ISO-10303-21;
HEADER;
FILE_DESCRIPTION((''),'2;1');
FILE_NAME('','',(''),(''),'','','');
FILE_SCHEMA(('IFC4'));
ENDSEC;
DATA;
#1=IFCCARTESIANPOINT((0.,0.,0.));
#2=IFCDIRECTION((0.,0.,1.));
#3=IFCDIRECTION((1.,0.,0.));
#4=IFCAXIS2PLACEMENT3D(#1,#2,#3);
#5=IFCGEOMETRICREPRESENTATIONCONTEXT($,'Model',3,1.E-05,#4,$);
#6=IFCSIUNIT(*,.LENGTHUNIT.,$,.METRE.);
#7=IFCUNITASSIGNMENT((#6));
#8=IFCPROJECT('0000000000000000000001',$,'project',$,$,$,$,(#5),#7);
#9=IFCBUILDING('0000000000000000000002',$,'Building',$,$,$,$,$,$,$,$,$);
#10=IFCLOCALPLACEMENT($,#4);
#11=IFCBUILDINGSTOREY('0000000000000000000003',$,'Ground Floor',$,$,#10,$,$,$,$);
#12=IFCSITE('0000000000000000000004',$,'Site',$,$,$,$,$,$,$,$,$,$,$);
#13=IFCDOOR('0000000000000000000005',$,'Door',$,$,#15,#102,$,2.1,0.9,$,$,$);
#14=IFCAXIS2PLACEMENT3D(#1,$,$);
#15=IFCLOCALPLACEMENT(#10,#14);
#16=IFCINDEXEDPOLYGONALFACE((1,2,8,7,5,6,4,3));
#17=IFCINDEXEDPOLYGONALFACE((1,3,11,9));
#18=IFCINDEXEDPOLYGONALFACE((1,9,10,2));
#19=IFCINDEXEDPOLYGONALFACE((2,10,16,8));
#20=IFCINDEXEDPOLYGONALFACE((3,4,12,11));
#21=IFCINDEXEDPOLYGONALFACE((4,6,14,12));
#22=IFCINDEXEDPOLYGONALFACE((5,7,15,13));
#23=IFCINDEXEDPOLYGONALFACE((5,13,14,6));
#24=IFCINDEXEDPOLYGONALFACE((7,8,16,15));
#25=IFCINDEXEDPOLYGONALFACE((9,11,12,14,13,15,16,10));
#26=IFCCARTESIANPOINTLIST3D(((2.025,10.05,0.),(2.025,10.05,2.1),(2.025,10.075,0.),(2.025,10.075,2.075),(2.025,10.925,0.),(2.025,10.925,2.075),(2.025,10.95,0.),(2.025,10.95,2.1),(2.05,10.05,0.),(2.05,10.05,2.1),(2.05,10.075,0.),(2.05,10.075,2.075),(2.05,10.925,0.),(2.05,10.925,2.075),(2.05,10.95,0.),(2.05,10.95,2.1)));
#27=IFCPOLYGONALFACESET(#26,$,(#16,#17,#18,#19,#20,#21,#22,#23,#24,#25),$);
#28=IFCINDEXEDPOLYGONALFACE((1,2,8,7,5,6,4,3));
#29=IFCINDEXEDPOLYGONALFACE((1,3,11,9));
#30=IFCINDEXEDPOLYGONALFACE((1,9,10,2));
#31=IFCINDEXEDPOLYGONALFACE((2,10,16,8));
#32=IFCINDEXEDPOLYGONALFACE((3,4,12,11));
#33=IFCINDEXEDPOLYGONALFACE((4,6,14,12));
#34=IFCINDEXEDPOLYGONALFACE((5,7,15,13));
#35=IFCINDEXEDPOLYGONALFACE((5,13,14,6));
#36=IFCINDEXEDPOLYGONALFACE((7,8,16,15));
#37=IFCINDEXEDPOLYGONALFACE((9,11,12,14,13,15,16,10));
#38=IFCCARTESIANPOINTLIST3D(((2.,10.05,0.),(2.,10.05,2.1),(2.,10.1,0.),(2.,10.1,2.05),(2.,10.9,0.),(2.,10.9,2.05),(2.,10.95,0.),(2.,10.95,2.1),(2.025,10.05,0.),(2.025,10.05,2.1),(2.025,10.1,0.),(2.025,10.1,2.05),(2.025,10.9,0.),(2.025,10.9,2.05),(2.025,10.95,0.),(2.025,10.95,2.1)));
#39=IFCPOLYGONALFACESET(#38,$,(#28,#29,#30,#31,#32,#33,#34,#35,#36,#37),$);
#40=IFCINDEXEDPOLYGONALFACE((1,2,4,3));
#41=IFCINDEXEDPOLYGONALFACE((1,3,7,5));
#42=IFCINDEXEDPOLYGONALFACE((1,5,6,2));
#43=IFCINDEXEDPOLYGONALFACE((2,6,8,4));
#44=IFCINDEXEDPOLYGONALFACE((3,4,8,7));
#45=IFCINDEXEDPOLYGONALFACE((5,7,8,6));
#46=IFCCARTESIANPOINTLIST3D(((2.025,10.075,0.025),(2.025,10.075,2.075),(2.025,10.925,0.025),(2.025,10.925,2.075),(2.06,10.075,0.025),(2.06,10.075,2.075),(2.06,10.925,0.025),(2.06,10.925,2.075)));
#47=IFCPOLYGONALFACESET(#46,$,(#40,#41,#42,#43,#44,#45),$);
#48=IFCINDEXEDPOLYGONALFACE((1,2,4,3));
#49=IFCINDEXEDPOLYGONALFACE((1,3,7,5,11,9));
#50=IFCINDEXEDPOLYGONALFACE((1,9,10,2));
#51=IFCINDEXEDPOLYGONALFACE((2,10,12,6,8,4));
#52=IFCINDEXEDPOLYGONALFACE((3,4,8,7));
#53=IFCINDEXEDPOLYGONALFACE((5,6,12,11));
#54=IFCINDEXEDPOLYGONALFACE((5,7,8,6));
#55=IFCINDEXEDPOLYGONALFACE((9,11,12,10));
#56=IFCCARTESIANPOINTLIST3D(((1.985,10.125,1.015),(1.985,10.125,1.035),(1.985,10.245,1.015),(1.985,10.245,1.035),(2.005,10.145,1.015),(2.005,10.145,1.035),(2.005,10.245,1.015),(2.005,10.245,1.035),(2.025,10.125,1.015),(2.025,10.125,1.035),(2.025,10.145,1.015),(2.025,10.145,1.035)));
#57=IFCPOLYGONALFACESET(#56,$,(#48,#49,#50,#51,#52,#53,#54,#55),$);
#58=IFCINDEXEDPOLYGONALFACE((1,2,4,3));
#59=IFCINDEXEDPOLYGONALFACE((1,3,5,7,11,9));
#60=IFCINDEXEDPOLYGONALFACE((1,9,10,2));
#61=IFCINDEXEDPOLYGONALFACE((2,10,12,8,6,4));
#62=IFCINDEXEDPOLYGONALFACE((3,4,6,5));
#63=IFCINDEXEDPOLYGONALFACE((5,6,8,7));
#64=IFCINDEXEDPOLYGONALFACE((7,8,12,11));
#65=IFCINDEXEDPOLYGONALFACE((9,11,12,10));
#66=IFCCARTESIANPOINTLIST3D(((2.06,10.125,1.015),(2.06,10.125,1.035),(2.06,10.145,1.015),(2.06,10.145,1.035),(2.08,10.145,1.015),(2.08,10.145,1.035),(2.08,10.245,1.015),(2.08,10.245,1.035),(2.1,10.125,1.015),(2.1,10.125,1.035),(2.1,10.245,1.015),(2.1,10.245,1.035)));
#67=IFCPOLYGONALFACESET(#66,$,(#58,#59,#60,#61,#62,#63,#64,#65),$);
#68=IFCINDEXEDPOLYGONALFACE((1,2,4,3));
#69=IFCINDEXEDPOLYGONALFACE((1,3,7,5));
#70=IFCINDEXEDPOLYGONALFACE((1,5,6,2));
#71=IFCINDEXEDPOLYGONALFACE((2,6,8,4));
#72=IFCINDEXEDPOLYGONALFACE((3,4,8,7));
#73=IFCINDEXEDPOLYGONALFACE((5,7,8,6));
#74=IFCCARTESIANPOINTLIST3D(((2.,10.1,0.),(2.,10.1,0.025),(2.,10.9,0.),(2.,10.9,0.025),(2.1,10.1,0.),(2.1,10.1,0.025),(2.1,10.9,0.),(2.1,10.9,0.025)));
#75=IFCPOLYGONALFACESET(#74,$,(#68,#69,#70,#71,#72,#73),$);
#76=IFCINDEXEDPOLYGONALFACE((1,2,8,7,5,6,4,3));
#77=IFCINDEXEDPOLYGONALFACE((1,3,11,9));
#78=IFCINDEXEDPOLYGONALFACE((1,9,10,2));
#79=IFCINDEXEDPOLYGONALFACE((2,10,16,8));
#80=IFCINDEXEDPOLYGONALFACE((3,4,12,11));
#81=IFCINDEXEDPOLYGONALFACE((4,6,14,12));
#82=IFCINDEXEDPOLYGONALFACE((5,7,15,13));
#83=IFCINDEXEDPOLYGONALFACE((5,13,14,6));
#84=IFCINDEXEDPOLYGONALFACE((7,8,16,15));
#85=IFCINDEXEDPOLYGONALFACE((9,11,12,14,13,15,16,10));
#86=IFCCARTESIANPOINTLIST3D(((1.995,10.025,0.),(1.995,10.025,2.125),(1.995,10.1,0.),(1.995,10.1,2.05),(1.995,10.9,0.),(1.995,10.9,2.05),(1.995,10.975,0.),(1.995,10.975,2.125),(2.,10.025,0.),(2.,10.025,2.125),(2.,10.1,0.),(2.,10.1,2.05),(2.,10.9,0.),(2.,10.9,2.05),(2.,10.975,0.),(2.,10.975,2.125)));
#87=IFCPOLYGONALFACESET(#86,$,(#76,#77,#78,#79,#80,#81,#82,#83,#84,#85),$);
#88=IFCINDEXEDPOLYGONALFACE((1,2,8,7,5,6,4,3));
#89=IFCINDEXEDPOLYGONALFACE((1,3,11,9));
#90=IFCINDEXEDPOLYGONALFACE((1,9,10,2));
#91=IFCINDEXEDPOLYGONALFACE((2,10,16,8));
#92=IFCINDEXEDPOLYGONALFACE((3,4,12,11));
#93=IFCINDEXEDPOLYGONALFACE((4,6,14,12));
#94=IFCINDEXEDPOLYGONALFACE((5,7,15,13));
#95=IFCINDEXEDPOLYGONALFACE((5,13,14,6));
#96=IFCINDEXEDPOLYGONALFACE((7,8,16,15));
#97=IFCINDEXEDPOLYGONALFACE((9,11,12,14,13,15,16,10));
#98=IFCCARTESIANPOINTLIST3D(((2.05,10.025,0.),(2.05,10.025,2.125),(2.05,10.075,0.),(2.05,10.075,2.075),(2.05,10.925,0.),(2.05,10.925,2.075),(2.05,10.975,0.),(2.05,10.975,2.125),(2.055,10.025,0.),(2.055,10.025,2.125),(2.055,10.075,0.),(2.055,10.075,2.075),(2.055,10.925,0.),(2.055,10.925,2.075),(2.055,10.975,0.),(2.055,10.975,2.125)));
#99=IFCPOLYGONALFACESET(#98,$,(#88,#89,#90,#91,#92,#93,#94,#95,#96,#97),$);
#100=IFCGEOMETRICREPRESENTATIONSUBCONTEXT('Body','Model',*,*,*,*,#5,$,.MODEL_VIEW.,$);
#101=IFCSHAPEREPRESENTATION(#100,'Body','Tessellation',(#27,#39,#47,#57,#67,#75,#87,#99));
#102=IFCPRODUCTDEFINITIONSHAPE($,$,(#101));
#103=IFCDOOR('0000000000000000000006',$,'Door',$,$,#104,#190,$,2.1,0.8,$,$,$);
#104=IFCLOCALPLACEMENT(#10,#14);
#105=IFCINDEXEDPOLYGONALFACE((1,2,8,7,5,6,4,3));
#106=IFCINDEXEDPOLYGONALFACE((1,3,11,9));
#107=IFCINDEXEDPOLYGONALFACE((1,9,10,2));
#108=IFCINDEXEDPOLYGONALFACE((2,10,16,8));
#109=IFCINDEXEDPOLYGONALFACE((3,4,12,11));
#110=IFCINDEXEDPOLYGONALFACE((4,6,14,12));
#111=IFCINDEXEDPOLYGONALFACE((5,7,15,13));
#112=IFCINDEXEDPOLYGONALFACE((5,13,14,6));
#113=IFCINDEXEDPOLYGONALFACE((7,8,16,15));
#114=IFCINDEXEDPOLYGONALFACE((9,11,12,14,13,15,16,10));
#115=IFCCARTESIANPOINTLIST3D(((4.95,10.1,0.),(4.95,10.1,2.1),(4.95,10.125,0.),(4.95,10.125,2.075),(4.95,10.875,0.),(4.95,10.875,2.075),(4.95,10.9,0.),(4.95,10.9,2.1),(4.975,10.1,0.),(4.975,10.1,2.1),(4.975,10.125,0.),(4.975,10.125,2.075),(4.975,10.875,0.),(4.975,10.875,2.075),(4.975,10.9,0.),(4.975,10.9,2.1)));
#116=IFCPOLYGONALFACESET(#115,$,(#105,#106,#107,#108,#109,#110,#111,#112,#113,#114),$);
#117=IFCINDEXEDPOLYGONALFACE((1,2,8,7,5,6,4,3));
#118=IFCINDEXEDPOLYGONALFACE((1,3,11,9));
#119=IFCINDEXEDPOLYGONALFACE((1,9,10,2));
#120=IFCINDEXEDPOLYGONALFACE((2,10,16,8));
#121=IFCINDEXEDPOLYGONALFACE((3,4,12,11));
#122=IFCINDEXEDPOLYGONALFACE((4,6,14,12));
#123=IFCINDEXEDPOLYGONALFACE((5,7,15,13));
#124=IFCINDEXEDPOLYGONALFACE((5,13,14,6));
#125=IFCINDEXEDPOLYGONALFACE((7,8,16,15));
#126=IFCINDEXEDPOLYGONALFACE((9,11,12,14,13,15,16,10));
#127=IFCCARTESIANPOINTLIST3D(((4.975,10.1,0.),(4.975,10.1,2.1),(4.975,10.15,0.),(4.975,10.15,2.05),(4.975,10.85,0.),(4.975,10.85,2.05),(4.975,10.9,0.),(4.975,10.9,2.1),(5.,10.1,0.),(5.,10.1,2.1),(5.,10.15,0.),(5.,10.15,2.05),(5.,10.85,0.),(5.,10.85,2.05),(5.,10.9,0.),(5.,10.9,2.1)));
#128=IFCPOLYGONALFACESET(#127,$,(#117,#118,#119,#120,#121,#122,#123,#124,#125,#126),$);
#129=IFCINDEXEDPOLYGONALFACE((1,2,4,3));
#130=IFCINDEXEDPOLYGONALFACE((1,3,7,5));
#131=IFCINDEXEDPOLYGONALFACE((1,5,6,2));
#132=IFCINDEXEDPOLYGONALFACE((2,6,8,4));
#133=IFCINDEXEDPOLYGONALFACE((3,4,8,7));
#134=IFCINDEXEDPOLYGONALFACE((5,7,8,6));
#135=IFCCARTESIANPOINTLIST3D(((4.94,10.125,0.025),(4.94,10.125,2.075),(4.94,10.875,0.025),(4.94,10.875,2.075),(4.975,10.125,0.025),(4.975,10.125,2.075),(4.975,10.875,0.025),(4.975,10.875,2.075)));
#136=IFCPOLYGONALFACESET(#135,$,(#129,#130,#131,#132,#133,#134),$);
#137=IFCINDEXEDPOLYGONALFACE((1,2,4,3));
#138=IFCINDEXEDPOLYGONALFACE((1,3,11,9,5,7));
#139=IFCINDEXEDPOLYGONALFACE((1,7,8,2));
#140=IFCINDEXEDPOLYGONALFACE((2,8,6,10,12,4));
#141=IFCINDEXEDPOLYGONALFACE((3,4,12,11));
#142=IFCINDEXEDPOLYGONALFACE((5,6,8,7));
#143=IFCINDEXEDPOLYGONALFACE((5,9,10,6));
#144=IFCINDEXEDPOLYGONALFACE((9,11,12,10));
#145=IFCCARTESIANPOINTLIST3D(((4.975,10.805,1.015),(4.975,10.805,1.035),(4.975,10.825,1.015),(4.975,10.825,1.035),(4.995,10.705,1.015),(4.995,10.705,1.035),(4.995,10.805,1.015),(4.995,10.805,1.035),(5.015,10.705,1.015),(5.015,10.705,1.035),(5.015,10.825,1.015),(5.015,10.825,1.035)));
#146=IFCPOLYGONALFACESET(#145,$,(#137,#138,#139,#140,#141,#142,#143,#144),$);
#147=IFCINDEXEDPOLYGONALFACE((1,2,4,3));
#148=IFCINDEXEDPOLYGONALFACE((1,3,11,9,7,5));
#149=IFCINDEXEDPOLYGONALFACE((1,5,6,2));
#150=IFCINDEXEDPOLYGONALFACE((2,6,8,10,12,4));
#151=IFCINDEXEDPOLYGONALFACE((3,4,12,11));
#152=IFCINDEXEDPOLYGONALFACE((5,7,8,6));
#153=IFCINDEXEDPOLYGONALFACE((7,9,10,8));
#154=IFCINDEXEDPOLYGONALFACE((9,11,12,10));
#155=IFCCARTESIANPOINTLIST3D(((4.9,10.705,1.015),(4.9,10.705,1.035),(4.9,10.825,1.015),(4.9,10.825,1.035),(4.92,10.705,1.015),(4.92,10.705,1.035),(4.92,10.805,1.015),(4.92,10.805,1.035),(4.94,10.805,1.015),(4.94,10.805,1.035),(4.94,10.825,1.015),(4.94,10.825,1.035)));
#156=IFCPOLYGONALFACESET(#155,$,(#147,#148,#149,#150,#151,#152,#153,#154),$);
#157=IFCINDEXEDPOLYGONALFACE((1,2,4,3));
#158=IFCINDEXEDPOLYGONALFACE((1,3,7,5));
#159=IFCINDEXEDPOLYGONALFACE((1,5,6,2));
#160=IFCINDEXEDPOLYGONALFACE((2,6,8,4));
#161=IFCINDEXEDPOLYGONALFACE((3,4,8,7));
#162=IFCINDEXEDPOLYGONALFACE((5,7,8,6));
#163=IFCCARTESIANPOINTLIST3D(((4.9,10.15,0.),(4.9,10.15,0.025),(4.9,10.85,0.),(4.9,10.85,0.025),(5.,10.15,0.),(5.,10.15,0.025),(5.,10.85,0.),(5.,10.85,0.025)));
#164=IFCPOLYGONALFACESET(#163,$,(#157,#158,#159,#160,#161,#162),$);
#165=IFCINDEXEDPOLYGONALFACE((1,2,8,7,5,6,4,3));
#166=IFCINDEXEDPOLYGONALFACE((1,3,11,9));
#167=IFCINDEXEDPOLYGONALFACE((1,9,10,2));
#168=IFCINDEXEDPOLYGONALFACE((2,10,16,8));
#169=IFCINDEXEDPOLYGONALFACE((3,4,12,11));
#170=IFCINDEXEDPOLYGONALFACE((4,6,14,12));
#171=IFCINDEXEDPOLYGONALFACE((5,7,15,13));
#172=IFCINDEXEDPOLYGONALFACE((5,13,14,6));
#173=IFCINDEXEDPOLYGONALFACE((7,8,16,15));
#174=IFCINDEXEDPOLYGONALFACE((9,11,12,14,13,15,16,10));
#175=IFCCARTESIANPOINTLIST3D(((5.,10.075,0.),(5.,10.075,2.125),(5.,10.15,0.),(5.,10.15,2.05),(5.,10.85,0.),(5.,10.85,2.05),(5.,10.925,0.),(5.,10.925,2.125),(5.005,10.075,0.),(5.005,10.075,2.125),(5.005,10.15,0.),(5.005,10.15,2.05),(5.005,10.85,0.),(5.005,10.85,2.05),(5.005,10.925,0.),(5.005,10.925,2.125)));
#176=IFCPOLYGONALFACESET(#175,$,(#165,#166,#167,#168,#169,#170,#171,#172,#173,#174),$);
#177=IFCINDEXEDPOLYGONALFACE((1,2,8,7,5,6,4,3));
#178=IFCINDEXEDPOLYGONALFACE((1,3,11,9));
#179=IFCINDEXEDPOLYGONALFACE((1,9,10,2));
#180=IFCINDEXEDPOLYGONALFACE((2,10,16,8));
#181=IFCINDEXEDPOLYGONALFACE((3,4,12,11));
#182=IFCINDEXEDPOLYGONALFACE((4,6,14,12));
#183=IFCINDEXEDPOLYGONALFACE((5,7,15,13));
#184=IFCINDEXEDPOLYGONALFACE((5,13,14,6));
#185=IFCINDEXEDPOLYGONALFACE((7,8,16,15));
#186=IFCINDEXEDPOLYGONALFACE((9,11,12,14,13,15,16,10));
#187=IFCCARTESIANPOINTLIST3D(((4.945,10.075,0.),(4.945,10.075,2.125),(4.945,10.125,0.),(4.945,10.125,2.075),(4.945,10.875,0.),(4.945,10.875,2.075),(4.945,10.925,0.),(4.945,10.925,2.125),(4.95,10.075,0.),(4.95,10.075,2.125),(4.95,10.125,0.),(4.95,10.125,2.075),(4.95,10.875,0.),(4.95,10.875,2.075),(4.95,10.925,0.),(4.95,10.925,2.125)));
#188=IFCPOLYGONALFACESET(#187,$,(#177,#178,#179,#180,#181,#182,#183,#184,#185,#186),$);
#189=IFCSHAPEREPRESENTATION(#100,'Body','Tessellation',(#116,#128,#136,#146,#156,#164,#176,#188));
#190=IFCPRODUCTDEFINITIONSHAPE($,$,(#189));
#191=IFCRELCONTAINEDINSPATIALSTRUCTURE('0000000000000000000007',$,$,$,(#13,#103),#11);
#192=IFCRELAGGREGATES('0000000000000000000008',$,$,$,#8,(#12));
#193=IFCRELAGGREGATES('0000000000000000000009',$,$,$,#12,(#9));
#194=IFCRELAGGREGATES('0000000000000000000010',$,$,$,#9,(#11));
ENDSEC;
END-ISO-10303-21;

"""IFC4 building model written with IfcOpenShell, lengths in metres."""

from ifc_helpers import new_model, si_unit, frame, origin_with_axes, place, context, subcontext, project, spatial, line, indexed_curve, outline, extrude, element, save


model = new_model("IFC4")

# Units and contexts
model_context = context("Model", 3, precision=1e-05, world=origin_with_axes())
body_context = subcontext(model_context, "Body", "Model", "MODEL_VIEW")
ifc_project = project(units=[si_unit("LENGTHUNIT", "METRE")], contexts=[model_context])

# Site, building, storey
site = spatial("IfcSite", under=ifc_project, Name="Site")
building = spatial("IfcBuilding", under=site, Name="Building")
storey_placement = place(None, origin_with_axes())
storey = spatial("IfcBuildingStorey", under=building, at=storey_placement, Name="Ground Floor")

# Doors
door_1_placement = place(storey_placement, frame((2.0, 10.95, 0.0), z_axis=(0.0, 0.0, 1.0), x_axis=(0.0, -1.0, 0.0)))
element("IfcDoor", 1, at=door_1_placement, inside=storey, Name="Door", OverallHeight=2.1, OverallWidth=0.9, context=body_context, shape_type="SweptSolid", body=[
    extrude(outline(indexed_curve([(0.0, 0.0), (0.0, 2.1), (0.9, 2.1), (0.9, 0.0), (0.875, 0.0), (0.875, 2.075), (0.025, 2.075), (0.025, 0.0)], segments=[line(1, 2, 3, 4, 5, 6, 7, 8, 1)])), frame((0.0, 0.025, 0.0), z_axis=(0.0, -1.0, 0.0), x_axis=(1.0, 0.0, 0.0)), (0.0, 0.0, -1.0), 0.025),
    extrude(outline(indexed_curve([(0.0, 0.0), (0.0, 2.1), (0.9, 2.1), (0.9, 0.0), (0.85, 0.0), (0.85, 2.05), (0.05, 2.05), (0.05, 0.0)], segments=[line(1, 2, 3, 4, 5, 6, 7, 8, 1)])), frame((0.0, 0.0, 0.0), z_axis=(0.0, -1.0, 0.0), x_axis=(1.0, 0.0, 0.0)), (0.0, 0.0, -1.0), 0.025),
    extrude(outline(indexed_curve([(0.0, 0.0), (0.85, 0.0), (0.85, 0.035), (0.0, 0.035)], segments=[line(1, 2, 3, 4, 1)])), frame((0.025, 0.025, 0.025), z_axis=(0.0, 0.0, 1.0), x_axis=(1.0, 0.0, 0.0)), (0.0, 0.0, 1.0), 2.05),
    extrude(outline(indexed_curve([(0.0, 0.0), (0.0, -0.04), (-0.12, -0.04), (-0.12, -0.02), (-0.02, -0.02), (-0.02, 0.0)], segments=[line(1, 2, 3, 4, 5, 6, 1)])), frame((0.825, 0.025, 1.015), z_axis=(0.0, 0.0, 1.0), x_axis=(1.0, 0.0, 0.0)), (0.0, 0.0, 1.0), 0.02),
    extrude(outline(indexed_curve([(0.0, 0.0), (0.0, 0.04), (-0.12, 0.04), (-0.12, 0.02), (-0.02, 0.02), (-0.02, 0.0)], segments=[line(1, 2, 3, 4, 5, 6, 1)])), frame((0.825, 0.06, 1.015), z_axis=(0.0, 0.0, 1.0), x_axis=(1.0, 0.0, 0.0)), (0.0, 0.0, 1.0), 0.02),
    extrude(outline(indexed_curve([(0.0, 0.0), (0.8, 0.0), (0.8, 0.1), (0.0, 0.1)], segments=[line(1, 2, 3, 4, 1)])), frame((0.05, 0.0, 0.0), z_axis=(0.0, 0.0, 1.0), x_axis=(1.0, 0.0, 0.0)), (0.0, 0.0, 1.0), 0.025),
    extrude(outline(indexed_curve([(0.0, 0.0), (0.0, 2.125), (0.95, 2.125), (0.95, 0.0), (0.875, 0.0), (0.875, 2.05), (0.075, 2.05), (0.075, 0.0)], segments=[line(1, 2, 3, 4, 5, 6, 7, 8, 1)])), frame((-0.025, -0.005, 0.0), z_axis=(0.0, -1.0, 0.0), x_axis=(1.0, 0.0, 0.0)), (0.0, 0.0, -1.0), 0.005),
    extrude(outline(indexed_curve([(0.0, 0.0), (0.0, 2.125), (0.95, 2.125), (0.95, 0.0), (0.9, 0.0), (0.9, 2.075), (0.05, 2.075), (0.05, 0.0)], segments=[line(1, 2, 3, 4, 5, 6, 7, 8, 1)])), frame((-0.025, 0.05, 0.0), z_axis=(0.0, -1.0, 0.0), x_axis=(1.0, 0.0, 0.0)), (0.0, 0.0, -1.0), 0.005),
])
door_2_placement = place(storey_placement, frame((5.0, 10.1, 0.0), z_axis=(0.0, 0.0, 1.0), x_axis=(0.0, 1.0, 0.0)))
element("IfcDoor", 2, at=door_2_placement, inside=storey, Name="Door", OverallHeight=2.1, OverallWidth=0.8, context=body_context, shape_type="SweptSolid", body=[
    extrude(outline(indexed_curve([(0.0, 0.0), (0.0, 2.1), (0.8, 2.1), (0.8, 0.0), (0.775, 0.0), (0.775, 2.075), (0.025, 2.075), (0.025, 0.0)], segments=[line(1, 2, 3, 4, 5, 6, 7, 8, 1)])), frame((0.0, 0.025, 0.0), z_axis=(0.0, -1.0, 0.0), x_axis=(1.0, 0.0, 0.0)), (0.0, 0.0, -1.0), 0.025),
    extrude(outline(indexed_curve([(0.0, 0.0), (0.0, 2.1), (0.8, 2.1), (0.8, 0.0), (0.75, 0.0), (0.75, 2.05), (0.05, 2.05), (0.05, 0.0)], segments=[line(1, 2, 3, 4, 5, 6, 7, 8, 1)])), frame((0.0, 0.0, 0.0), z_axis=(0.0, -1.0, 0.0), x_axis=(1.0, 0.0, 0.0)), (0.0, 0.0, -1.0), 0.025),
    extrude(outline(indexed_curve([(0.0, 0.0), (0.75, 0.0), (0.75, 0.035), (0.0, 0.035)], segments=[line(1, 2, 3, 4, 1)])), frame((0.025, 0.025, 0.025), z_axis=(0.0, 0.0, 1.0), x_axis=(1.0, 0.0, 0.0)), (0.0, 0.0, 1.0), 2.05),
    extrude(outline(indexed_curve([(0.0, 0.0), (0.0, -0.04), (-0.12, -0.04), (-0.12, -0.02), (-0.02, -0.02), (-0.02, 0.0)], segments=[line(1, 2, 3, 4, 5, 6, 1)])), frame((0.725, 0.025, 1.015), z_axis=(0.0, 0.0, 1.0), x_axis=(1.0, 0.0, 0.0)), (0.0, 0.0, 1.0), 0.02),
    extrude(outline(indexed_curve([(0.0, 0.0), (0.0, 0.04), (-0.12, 0.04), (-0.12, 0.02), (-0.02, 0.02), (-0.02, 0.0)], segments=[line(1, 2, 3, 4, 5, 6, 1)])), frame((0.725, 0.06, 1.015), z_axis=(0.0, 0.0, 1.0), x_axis=(1.0, 0.0, 0.0)), (0.0, 0.0, 1.0), 0.02),
    extrude(outline(indexed_curve([(0.0, 0.0), (0.7, 0.0), (0.7, 0.1), (0.0, 0.1)], segments=[line(1, 2, 3, 4, 1)])), frame((0.05, 0.0, 0.0), z_axis=(0.0, 0.0, 1.0), x_axis=(1.0, 0.0, 0.0)), (0.0, 0.0, 1.0), 0.025),
    extrude(outline(indexed_curve([(0.0, 0.0), (0.0, 2.125), (0.85, 2.125), (0.85, 0.0), (0.775, 0.0), (0.775, 2.05), (0.075, 2.05), (0.075, 0.0)], segments=[line(1, 2, 3, 4, 5, 6, 7, 8, 1)])), frame((-0.025, -0.005, 0.0), z_axis=(0.0, -1.0, 0.0), x_axis=(1.0, 0.0, 0.0)), (0.0, 0.0, -1.0), 0.005),
    extrude(outline(indexed_curve([(0.0, 0.0), (0.0, 2.125), (0.85, 2.125), (0.85, 0.0), (0.8, 0.0), (0.8, 2.075), (0.05, 2.075), (0.05, 0.0)], segments=[line(1, 2, 3, 4, 5, 6, 7, 8, 1)])), frame((-0.025, 0.05, 0.0), z_axis=(0.0, -1.0, 0.0), x_axis=(1.0, 0.0, 0.0)), (0.0, 0.0, -1.0), 0.005),
])

save(model, "model.ifc")
